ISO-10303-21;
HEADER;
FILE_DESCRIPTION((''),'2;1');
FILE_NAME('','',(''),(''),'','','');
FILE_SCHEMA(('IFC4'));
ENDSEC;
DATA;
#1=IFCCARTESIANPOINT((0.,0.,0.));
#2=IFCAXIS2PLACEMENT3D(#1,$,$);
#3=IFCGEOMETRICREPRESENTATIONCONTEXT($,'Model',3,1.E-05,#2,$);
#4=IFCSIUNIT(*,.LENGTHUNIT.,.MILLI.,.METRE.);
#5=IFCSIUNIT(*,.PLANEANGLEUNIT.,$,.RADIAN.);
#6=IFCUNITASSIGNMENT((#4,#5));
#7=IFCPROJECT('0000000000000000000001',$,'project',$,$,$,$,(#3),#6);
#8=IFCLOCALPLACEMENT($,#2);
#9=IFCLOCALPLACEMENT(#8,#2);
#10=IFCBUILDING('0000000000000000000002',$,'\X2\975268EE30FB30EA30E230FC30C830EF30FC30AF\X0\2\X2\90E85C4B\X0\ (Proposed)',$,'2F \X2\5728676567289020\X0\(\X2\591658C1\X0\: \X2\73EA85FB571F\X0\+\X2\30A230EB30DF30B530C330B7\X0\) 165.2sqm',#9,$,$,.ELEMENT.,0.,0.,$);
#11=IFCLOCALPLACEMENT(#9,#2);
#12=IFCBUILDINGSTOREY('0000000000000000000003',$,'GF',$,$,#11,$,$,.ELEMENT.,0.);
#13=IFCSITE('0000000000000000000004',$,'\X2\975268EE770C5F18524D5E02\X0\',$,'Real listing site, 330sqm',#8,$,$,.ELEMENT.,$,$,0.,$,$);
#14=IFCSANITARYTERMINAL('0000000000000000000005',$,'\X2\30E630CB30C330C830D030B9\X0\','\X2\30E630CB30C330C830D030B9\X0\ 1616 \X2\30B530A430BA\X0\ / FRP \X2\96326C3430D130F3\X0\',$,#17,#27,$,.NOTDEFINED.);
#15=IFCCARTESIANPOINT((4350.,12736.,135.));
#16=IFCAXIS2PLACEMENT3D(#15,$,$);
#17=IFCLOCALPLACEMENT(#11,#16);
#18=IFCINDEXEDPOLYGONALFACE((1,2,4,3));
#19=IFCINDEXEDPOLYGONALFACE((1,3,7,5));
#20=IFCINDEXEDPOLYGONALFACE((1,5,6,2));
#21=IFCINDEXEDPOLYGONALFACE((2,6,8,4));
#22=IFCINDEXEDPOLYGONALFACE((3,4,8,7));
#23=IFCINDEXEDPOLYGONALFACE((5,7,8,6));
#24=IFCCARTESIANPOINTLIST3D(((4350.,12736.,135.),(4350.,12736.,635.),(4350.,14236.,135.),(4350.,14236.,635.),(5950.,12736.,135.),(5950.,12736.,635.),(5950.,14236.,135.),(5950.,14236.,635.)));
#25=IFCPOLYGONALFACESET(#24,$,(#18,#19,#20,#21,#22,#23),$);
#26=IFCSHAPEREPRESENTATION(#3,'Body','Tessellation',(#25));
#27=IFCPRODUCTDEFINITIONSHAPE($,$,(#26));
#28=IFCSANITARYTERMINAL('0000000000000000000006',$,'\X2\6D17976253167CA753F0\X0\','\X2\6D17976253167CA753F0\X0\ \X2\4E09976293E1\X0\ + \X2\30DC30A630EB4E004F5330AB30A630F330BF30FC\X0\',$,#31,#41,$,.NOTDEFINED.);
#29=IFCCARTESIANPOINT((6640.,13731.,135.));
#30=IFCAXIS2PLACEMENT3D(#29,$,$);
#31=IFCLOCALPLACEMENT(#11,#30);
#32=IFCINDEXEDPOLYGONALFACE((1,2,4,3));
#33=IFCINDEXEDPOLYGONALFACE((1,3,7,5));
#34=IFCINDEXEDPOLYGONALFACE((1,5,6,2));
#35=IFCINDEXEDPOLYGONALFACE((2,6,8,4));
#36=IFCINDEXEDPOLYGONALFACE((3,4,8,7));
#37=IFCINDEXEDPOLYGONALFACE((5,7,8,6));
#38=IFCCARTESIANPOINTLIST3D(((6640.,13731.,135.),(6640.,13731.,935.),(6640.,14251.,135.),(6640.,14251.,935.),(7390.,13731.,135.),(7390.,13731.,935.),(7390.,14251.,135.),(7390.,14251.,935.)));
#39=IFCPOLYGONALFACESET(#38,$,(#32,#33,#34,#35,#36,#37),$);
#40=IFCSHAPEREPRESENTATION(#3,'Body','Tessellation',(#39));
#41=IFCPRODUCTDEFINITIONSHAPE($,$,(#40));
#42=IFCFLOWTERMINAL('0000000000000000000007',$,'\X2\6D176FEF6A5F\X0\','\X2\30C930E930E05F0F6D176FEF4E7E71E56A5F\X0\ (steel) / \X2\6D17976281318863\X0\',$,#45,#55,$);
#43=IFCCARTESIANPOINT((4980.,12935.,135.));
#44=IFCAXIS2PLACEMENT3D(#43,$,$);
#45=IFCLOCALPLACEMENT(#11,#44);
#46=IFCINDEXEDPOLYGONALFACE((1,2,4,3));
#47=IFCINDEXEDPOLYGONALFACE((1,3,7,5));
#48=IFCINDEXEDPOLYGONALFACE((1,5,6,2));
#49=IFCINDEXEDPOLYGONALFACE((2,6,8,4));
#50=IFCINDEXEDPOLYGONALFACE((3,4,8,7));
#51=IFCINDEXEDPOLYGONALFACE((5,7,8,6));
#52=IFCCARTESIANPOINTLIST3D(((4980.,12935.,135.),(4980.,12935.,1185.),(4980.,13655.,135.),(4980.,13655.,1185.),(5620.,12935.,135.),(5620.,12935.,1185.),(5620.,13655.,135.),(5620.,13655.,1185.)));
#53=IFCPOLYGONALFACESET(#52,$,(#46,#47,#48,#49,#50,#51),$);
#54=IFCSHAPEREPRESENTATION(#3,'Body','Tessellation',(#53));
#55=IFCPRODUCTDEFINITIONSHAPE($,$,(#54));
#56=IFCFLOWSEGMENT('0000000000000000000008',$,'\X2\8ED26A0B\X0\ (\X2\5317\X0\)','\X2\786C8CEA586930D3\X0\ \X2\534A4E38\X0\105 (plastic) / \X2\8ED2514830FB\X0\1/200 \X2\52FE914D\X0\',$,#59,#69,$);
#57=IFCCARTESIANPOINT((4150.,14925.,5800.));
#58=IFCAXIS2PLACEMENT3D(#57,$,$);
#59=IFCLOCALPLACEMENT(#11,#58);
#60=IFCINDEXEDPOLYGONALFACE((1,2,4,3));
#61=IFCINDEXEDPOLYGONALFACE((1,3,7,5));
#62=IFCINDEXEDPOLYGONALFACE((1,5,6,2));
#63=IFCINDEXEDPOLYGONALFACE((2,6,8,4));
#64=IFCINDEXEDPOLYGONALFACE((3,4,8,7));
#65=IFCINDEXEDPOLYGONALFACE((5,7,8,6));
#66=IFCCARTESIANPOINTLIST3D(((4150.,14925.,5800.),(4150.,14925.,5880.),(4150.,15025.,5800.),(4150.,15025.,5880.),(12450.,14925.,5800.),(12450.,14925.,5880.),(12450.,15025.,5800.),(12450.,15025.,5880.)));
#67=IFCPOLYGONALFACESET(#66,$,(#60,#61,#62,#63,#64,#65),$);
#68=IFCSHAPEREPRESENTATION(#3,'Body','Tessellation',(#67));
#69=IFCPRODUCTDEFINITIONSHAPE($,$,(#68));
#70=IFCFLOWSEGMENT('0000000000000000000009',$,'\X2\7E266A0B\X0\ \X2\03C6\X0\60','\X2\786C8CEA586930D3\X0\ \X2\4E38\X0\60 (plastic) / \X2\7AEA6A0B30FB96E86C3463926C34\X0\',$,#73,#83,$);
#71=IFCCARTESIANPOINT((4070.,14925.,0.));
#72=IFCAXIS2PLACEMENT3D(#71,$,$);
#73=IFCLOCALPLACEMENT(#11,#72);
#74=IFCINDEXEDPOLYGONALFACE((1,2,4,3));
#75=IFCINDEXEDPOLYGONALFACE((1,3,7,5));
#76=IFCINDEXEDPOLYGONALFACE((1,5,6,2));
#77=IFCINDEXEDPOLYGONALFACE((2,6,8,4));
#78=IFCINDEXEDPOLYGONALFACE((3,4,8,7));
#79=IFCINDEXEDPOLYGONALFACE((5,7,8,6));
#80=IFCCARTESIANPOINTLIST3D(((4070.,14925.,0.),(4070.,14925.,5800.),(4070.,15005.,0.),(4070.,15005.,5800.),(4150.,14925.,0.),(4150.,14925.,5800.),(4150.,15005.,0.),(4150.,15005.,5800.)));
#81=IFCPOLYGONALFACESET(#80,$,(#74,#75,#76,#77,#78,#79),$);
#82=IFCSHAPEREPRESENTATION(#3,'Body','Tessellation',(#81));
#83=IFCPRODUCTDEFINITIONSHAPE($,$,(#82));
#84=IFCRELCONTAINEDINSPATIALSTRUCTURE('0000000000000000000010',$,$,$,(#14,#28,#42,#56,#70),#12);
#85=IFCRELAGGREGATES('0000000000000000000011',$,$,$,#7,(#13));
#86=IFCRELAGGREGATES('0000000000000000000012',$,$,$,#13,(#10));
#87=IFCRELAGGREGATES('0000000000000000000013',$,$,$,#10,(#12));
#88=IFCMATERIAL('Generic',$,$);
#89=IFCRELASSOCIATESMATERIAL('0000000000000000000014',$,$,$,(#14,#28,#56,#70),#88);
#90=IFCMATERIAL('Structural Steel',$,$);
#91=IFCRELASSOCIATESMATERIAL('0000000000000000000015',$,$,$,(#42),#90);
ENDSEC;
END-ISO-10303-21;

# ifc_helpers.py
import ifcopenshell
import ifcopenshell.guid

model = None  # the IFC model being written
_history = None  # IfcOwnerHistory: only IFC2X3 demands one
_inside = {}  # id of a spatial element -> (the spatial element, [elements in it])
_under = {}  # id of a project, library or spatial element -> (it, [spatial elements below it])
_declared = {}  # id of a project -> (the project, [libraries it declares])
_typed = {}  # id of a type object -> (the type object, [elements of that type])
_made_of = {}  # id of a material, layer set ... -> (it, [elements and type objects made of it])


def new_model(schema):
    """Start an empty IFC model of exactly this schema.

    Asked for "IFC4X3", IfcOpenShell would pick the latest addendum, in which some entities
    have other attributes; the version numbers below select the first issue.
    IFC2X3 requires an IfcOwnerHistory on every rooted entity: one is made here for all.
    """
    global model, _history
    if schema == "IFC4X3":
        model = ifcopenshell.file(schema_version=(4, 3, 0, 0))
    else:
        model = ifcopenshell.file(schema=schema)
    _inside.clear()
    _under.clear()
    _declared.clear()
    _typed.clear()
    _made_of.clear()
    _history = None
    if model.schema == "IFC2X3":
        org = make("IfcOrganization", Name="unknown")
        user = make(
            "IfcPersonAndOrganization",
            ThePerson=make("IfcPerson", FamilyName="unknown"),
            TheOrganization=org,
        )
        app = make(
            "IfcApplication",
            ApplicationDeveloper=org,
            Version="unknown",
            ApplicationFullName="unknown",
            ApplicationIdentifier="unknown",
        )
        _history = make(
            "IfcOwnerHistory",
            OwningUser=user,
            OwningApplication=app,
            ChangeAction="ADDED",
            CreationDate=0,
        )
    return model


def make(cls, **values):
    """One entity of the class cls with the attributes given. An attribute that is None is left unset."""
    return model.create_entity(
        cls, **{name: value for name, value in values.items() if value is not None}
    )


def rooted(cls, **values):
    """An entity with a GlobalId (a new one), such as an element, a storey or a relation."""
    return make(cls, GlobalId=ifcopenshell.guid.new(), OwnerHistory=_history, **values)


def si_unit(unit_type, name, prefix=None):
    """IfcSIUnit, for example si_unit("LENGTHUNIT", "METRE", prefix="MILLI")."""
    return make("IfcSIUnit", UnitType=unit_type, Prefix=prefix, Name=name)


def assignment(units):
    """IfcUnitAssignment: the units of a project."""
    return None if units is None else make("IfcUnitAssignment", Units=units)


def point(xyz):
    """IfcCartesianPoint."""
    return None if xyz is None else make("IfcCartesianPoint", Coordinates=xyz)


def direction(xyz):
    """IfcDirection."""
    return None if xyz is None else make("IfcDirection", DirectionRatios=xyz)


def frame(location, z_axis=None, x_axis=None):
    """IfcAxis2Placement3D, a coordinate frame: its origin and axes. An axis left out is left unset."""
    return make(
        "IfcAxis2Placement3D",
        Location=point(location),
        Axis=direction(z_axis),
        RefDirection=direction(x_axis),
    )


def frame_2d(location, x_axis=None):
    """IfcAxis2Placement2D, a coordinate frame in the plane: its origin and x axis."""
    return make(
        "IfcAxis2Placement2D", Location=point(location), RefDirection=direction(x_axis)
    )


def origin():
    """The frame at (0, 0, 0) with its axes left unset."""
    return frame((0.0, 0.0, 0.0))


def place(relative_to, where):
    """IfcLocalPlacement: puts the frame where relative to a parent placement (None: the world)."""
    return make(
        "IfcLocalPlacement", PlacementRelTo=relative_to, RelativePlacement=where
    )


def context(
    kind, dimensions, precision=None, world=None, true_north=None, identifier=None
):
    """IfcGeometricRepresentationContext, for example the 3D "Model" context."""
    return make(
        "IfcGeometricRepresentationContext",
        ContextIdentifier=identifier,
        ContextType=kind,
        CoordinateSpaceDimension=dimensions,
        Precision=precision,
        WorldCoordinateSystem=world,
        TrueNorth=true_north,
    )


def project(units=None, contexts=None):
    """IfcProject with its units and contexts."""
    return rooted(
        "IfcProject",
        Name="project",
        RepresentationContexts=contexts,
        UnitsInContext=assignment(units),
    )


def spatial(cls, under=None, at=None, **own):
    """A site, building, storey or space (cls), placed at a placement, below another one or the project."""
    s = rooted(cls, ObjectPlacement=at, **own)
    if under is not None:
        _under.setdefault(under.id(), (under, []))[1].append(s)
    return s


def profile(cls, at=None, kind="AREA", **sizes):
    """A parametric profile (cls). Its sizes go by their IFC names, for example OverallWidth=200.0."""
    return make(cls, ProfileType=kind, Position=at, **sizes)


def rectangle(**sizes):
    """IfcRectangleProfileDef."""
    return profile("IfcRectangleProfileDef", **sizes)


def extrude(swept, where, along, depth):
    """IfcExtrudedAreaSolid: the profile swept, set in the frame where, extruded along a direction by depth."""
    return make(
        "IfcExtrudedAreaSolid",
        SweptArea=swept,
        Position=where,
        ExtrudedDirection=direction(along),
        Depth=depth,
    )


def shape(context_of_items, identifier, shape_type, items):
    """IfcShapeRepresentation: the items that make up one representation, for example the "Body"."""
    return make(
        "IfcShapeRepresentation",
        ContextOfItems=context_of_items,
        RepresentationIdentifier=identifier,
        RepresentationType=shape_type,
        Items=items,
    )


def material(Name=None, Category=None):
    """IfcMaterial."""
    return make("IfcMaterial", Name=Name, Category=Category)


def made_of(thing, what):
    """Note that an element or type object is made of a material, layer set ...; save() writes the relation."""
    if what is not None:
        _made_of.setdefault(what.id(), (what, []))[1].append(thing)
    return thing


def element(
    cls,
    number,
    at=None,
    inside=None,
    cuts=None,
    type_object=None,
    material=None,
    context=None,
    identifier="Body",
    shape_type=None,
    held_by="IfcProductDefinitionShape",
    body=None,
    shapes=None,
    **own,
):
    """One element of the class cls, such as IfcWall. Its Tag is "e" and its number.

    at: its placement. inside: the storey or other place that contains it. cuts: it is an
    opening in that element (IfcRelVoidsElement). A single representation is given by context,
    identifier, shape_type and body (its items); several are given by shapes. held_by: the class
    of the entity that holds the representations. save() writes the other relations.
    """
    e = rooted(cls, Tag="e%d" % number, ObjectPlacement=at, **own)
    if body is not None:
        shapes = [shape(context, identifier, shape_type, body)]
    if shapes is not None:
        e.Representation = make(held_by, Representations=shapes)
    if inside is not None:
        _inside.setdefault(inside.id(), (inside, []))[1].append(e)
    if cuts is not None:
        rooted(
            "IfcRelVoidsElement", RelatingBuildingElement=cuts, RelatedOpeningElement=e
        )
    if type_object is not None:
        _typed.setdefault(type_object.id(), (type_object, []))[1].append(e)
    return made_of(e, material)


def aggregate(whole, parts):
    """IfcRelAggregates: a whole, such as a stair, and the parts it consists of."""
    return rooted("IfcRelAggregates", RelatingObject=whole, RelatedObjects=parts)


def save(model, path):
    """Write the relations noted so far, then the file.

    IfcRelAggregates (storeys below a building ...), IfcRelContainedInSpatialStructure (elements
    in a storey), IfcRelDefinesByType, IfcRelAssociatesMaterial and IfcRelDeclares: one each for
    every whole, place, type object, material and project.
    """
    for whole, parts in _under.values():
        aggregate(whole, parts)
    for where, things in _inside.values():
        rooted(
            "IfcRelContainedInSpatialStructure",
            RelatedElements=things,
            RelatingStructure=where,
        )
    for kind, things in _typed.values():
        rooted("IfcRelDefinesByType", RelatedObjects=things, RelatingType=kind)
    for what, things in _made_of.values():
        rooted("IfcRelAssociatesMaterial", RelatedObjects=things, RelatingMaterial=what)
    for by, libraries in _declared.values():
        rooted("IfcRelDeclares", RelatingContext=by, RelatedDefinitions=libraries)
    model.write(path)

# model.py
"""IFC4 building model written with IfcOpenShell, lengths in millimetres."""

from ifc_helpers import new_model, si_unit, frame, frame_2d, origin, place, context, project, spatial, rectangle, extrude, material, element, save


model = new_model("IFC4")

# Units and contexts
model_context = context("Model", 3, precision=1e-05, world=origin())
ifc_project = project(units=[si_unit("LENGTHUNIT", "METRE", prefix="MILLI"), si_unit("PLANEANGLEUNIT", "RADIAN")], contexts=[model_context])

# Site, building, storey
site_placement = place(None, origin())
site = spatial("IfcSite", under=ifc_project, at=site_placement, Name="青森県弘前市", ObjectType="Real listing site, 330sqm", CompositionType="ELEMENT", RefElevation=0.0)
building_placement = place(site_placement, origin())
building = spatial("IfcBuilding", under=site, at=building_placement, Name="青森・リモートワーク2部屋 (Proposed)", ObjectType="2F 在来木造(外壁: 珪藻土+アルミサッシ) 165.2sqm", CompositionType="ELEMENT", ElevationOfRefHeight=0.0, ElevationOfTerrain=0.0)
storey_placement = place(building_placement, origin())
storey = spatial("IfcBuildingStorey", under=building, at=storey_placement, Name="GF", CompositionType="ELEMENT", Elevation=0.0)

# Sanitary terminals
ifc_material_1 = material(Name="Generic")
sanitary_terminal_1_placement = place(storey_placement, frame((4350.0, 12736.0, 135.0)))
element("IfcSanitaryTerminal", 1, at=sanitary_terminal_1_placement, inside=storey, material=ifc_material_1, Name="ユニットバス", Description="ユニットバス 1616 サイズ / FRP 防水パン", PredefinedType="NOTDEFINED", context=model_context, shape_type="SweptSolid", body=[
    extrude(rectangle(XDim=1600.0, YDim=1500.0, at=frame_2d((800.0, 750.0))), frame((4350.0, 12736.0, 135.0)), (0.0, 0.0, 1.0), 500.0),
])
sanitary_terminal_2_placement = place(storey_placement, frame((6640.0, 13731.0, 135.0)))
element("IfcSanitaryTerminal", 2, at=sanitary_terminal_2_placement, inside=storey, material=ifc_material_1, Name="洗面化粧台", Description="洗面化粧台 三面鏡 + ボウル一体カウンター", PredefinedType="NOTDEFINED", context=model_context, shape_type="SweptSolid", body=[
    extrude(rectangle(XDim=750.0, YDim=520.0, at=frame_2d((375.0, 260.0))), frame((6640.0, 13731.0, 135.0)), (0.0, 0.0, 1.0), 800.0),
])

# Flow terminal
ifc_material_2 = material(Name="Structural Steel")
flow_terminal_placement = place(storey_placement, frame((4980.0, 12935.0, 135.0)))
element("IfcFlowTerminal", 3, at=flow_terminal_placement, inside=storey, material=ifc_material_2, Name="洗濯機", Description="ドラム式洗濯乾燥機 (steel) / 洗面脱衣", context=model_context, shape_type="SweptSolid", body=[
    extrude(rectangle(XDim=640.0, YDim=720.0, at=frame_2d((320.0, 360.0))), frame((4980.0, 12935.0, 135.0)), (0.0, 0.0, 1.0), 1050.0),
])

# Flow segments
flow_segment_1_placement = place(storey_placement, frame((4150.0, 14925.0, 5800.0)))
element("IfcFlowSegment", 4, at=flow_segment_1_placement, inside=storey, material=ifc_material_1, Name="軒樋 (北)", Description="硬質塩ビ 半丸105 (plastic) / 軒先・1/200 勾配", context=model_context, shape_type="SweptSolid", body=[
    extrude(rectangle(XDim=8300.0, YDim=100.0, at=frame_2d((4150.0, 50.0))), frame((4150.0, 14925.0, 5800.0)), (0.0, 0.0, 1.0), 80.0),
])
flow_segment_2_placement = place(storey_placement, frame((4070.0, 14925.0, 0.0)))
element("IfcFlowSegment", 5, at=flow_segment_2_placement, inside=storey, material=ifc_material_1, Name="縦樋 φ60", Description="硬質塩ビ 丸60 (plastic) / 竪樋・雨水排水", context=model_context, shape_type="SweptSolid", body=[
    extrude(rectangle(XDim=80.0, YDim=80.0, at=frame_2d((40.0, 40.0))), frame((4070.0, 14925.0, 0.0)), (0.0, 0.0, 1.0), 5800.0),
])

save(model, "model.ifc")
